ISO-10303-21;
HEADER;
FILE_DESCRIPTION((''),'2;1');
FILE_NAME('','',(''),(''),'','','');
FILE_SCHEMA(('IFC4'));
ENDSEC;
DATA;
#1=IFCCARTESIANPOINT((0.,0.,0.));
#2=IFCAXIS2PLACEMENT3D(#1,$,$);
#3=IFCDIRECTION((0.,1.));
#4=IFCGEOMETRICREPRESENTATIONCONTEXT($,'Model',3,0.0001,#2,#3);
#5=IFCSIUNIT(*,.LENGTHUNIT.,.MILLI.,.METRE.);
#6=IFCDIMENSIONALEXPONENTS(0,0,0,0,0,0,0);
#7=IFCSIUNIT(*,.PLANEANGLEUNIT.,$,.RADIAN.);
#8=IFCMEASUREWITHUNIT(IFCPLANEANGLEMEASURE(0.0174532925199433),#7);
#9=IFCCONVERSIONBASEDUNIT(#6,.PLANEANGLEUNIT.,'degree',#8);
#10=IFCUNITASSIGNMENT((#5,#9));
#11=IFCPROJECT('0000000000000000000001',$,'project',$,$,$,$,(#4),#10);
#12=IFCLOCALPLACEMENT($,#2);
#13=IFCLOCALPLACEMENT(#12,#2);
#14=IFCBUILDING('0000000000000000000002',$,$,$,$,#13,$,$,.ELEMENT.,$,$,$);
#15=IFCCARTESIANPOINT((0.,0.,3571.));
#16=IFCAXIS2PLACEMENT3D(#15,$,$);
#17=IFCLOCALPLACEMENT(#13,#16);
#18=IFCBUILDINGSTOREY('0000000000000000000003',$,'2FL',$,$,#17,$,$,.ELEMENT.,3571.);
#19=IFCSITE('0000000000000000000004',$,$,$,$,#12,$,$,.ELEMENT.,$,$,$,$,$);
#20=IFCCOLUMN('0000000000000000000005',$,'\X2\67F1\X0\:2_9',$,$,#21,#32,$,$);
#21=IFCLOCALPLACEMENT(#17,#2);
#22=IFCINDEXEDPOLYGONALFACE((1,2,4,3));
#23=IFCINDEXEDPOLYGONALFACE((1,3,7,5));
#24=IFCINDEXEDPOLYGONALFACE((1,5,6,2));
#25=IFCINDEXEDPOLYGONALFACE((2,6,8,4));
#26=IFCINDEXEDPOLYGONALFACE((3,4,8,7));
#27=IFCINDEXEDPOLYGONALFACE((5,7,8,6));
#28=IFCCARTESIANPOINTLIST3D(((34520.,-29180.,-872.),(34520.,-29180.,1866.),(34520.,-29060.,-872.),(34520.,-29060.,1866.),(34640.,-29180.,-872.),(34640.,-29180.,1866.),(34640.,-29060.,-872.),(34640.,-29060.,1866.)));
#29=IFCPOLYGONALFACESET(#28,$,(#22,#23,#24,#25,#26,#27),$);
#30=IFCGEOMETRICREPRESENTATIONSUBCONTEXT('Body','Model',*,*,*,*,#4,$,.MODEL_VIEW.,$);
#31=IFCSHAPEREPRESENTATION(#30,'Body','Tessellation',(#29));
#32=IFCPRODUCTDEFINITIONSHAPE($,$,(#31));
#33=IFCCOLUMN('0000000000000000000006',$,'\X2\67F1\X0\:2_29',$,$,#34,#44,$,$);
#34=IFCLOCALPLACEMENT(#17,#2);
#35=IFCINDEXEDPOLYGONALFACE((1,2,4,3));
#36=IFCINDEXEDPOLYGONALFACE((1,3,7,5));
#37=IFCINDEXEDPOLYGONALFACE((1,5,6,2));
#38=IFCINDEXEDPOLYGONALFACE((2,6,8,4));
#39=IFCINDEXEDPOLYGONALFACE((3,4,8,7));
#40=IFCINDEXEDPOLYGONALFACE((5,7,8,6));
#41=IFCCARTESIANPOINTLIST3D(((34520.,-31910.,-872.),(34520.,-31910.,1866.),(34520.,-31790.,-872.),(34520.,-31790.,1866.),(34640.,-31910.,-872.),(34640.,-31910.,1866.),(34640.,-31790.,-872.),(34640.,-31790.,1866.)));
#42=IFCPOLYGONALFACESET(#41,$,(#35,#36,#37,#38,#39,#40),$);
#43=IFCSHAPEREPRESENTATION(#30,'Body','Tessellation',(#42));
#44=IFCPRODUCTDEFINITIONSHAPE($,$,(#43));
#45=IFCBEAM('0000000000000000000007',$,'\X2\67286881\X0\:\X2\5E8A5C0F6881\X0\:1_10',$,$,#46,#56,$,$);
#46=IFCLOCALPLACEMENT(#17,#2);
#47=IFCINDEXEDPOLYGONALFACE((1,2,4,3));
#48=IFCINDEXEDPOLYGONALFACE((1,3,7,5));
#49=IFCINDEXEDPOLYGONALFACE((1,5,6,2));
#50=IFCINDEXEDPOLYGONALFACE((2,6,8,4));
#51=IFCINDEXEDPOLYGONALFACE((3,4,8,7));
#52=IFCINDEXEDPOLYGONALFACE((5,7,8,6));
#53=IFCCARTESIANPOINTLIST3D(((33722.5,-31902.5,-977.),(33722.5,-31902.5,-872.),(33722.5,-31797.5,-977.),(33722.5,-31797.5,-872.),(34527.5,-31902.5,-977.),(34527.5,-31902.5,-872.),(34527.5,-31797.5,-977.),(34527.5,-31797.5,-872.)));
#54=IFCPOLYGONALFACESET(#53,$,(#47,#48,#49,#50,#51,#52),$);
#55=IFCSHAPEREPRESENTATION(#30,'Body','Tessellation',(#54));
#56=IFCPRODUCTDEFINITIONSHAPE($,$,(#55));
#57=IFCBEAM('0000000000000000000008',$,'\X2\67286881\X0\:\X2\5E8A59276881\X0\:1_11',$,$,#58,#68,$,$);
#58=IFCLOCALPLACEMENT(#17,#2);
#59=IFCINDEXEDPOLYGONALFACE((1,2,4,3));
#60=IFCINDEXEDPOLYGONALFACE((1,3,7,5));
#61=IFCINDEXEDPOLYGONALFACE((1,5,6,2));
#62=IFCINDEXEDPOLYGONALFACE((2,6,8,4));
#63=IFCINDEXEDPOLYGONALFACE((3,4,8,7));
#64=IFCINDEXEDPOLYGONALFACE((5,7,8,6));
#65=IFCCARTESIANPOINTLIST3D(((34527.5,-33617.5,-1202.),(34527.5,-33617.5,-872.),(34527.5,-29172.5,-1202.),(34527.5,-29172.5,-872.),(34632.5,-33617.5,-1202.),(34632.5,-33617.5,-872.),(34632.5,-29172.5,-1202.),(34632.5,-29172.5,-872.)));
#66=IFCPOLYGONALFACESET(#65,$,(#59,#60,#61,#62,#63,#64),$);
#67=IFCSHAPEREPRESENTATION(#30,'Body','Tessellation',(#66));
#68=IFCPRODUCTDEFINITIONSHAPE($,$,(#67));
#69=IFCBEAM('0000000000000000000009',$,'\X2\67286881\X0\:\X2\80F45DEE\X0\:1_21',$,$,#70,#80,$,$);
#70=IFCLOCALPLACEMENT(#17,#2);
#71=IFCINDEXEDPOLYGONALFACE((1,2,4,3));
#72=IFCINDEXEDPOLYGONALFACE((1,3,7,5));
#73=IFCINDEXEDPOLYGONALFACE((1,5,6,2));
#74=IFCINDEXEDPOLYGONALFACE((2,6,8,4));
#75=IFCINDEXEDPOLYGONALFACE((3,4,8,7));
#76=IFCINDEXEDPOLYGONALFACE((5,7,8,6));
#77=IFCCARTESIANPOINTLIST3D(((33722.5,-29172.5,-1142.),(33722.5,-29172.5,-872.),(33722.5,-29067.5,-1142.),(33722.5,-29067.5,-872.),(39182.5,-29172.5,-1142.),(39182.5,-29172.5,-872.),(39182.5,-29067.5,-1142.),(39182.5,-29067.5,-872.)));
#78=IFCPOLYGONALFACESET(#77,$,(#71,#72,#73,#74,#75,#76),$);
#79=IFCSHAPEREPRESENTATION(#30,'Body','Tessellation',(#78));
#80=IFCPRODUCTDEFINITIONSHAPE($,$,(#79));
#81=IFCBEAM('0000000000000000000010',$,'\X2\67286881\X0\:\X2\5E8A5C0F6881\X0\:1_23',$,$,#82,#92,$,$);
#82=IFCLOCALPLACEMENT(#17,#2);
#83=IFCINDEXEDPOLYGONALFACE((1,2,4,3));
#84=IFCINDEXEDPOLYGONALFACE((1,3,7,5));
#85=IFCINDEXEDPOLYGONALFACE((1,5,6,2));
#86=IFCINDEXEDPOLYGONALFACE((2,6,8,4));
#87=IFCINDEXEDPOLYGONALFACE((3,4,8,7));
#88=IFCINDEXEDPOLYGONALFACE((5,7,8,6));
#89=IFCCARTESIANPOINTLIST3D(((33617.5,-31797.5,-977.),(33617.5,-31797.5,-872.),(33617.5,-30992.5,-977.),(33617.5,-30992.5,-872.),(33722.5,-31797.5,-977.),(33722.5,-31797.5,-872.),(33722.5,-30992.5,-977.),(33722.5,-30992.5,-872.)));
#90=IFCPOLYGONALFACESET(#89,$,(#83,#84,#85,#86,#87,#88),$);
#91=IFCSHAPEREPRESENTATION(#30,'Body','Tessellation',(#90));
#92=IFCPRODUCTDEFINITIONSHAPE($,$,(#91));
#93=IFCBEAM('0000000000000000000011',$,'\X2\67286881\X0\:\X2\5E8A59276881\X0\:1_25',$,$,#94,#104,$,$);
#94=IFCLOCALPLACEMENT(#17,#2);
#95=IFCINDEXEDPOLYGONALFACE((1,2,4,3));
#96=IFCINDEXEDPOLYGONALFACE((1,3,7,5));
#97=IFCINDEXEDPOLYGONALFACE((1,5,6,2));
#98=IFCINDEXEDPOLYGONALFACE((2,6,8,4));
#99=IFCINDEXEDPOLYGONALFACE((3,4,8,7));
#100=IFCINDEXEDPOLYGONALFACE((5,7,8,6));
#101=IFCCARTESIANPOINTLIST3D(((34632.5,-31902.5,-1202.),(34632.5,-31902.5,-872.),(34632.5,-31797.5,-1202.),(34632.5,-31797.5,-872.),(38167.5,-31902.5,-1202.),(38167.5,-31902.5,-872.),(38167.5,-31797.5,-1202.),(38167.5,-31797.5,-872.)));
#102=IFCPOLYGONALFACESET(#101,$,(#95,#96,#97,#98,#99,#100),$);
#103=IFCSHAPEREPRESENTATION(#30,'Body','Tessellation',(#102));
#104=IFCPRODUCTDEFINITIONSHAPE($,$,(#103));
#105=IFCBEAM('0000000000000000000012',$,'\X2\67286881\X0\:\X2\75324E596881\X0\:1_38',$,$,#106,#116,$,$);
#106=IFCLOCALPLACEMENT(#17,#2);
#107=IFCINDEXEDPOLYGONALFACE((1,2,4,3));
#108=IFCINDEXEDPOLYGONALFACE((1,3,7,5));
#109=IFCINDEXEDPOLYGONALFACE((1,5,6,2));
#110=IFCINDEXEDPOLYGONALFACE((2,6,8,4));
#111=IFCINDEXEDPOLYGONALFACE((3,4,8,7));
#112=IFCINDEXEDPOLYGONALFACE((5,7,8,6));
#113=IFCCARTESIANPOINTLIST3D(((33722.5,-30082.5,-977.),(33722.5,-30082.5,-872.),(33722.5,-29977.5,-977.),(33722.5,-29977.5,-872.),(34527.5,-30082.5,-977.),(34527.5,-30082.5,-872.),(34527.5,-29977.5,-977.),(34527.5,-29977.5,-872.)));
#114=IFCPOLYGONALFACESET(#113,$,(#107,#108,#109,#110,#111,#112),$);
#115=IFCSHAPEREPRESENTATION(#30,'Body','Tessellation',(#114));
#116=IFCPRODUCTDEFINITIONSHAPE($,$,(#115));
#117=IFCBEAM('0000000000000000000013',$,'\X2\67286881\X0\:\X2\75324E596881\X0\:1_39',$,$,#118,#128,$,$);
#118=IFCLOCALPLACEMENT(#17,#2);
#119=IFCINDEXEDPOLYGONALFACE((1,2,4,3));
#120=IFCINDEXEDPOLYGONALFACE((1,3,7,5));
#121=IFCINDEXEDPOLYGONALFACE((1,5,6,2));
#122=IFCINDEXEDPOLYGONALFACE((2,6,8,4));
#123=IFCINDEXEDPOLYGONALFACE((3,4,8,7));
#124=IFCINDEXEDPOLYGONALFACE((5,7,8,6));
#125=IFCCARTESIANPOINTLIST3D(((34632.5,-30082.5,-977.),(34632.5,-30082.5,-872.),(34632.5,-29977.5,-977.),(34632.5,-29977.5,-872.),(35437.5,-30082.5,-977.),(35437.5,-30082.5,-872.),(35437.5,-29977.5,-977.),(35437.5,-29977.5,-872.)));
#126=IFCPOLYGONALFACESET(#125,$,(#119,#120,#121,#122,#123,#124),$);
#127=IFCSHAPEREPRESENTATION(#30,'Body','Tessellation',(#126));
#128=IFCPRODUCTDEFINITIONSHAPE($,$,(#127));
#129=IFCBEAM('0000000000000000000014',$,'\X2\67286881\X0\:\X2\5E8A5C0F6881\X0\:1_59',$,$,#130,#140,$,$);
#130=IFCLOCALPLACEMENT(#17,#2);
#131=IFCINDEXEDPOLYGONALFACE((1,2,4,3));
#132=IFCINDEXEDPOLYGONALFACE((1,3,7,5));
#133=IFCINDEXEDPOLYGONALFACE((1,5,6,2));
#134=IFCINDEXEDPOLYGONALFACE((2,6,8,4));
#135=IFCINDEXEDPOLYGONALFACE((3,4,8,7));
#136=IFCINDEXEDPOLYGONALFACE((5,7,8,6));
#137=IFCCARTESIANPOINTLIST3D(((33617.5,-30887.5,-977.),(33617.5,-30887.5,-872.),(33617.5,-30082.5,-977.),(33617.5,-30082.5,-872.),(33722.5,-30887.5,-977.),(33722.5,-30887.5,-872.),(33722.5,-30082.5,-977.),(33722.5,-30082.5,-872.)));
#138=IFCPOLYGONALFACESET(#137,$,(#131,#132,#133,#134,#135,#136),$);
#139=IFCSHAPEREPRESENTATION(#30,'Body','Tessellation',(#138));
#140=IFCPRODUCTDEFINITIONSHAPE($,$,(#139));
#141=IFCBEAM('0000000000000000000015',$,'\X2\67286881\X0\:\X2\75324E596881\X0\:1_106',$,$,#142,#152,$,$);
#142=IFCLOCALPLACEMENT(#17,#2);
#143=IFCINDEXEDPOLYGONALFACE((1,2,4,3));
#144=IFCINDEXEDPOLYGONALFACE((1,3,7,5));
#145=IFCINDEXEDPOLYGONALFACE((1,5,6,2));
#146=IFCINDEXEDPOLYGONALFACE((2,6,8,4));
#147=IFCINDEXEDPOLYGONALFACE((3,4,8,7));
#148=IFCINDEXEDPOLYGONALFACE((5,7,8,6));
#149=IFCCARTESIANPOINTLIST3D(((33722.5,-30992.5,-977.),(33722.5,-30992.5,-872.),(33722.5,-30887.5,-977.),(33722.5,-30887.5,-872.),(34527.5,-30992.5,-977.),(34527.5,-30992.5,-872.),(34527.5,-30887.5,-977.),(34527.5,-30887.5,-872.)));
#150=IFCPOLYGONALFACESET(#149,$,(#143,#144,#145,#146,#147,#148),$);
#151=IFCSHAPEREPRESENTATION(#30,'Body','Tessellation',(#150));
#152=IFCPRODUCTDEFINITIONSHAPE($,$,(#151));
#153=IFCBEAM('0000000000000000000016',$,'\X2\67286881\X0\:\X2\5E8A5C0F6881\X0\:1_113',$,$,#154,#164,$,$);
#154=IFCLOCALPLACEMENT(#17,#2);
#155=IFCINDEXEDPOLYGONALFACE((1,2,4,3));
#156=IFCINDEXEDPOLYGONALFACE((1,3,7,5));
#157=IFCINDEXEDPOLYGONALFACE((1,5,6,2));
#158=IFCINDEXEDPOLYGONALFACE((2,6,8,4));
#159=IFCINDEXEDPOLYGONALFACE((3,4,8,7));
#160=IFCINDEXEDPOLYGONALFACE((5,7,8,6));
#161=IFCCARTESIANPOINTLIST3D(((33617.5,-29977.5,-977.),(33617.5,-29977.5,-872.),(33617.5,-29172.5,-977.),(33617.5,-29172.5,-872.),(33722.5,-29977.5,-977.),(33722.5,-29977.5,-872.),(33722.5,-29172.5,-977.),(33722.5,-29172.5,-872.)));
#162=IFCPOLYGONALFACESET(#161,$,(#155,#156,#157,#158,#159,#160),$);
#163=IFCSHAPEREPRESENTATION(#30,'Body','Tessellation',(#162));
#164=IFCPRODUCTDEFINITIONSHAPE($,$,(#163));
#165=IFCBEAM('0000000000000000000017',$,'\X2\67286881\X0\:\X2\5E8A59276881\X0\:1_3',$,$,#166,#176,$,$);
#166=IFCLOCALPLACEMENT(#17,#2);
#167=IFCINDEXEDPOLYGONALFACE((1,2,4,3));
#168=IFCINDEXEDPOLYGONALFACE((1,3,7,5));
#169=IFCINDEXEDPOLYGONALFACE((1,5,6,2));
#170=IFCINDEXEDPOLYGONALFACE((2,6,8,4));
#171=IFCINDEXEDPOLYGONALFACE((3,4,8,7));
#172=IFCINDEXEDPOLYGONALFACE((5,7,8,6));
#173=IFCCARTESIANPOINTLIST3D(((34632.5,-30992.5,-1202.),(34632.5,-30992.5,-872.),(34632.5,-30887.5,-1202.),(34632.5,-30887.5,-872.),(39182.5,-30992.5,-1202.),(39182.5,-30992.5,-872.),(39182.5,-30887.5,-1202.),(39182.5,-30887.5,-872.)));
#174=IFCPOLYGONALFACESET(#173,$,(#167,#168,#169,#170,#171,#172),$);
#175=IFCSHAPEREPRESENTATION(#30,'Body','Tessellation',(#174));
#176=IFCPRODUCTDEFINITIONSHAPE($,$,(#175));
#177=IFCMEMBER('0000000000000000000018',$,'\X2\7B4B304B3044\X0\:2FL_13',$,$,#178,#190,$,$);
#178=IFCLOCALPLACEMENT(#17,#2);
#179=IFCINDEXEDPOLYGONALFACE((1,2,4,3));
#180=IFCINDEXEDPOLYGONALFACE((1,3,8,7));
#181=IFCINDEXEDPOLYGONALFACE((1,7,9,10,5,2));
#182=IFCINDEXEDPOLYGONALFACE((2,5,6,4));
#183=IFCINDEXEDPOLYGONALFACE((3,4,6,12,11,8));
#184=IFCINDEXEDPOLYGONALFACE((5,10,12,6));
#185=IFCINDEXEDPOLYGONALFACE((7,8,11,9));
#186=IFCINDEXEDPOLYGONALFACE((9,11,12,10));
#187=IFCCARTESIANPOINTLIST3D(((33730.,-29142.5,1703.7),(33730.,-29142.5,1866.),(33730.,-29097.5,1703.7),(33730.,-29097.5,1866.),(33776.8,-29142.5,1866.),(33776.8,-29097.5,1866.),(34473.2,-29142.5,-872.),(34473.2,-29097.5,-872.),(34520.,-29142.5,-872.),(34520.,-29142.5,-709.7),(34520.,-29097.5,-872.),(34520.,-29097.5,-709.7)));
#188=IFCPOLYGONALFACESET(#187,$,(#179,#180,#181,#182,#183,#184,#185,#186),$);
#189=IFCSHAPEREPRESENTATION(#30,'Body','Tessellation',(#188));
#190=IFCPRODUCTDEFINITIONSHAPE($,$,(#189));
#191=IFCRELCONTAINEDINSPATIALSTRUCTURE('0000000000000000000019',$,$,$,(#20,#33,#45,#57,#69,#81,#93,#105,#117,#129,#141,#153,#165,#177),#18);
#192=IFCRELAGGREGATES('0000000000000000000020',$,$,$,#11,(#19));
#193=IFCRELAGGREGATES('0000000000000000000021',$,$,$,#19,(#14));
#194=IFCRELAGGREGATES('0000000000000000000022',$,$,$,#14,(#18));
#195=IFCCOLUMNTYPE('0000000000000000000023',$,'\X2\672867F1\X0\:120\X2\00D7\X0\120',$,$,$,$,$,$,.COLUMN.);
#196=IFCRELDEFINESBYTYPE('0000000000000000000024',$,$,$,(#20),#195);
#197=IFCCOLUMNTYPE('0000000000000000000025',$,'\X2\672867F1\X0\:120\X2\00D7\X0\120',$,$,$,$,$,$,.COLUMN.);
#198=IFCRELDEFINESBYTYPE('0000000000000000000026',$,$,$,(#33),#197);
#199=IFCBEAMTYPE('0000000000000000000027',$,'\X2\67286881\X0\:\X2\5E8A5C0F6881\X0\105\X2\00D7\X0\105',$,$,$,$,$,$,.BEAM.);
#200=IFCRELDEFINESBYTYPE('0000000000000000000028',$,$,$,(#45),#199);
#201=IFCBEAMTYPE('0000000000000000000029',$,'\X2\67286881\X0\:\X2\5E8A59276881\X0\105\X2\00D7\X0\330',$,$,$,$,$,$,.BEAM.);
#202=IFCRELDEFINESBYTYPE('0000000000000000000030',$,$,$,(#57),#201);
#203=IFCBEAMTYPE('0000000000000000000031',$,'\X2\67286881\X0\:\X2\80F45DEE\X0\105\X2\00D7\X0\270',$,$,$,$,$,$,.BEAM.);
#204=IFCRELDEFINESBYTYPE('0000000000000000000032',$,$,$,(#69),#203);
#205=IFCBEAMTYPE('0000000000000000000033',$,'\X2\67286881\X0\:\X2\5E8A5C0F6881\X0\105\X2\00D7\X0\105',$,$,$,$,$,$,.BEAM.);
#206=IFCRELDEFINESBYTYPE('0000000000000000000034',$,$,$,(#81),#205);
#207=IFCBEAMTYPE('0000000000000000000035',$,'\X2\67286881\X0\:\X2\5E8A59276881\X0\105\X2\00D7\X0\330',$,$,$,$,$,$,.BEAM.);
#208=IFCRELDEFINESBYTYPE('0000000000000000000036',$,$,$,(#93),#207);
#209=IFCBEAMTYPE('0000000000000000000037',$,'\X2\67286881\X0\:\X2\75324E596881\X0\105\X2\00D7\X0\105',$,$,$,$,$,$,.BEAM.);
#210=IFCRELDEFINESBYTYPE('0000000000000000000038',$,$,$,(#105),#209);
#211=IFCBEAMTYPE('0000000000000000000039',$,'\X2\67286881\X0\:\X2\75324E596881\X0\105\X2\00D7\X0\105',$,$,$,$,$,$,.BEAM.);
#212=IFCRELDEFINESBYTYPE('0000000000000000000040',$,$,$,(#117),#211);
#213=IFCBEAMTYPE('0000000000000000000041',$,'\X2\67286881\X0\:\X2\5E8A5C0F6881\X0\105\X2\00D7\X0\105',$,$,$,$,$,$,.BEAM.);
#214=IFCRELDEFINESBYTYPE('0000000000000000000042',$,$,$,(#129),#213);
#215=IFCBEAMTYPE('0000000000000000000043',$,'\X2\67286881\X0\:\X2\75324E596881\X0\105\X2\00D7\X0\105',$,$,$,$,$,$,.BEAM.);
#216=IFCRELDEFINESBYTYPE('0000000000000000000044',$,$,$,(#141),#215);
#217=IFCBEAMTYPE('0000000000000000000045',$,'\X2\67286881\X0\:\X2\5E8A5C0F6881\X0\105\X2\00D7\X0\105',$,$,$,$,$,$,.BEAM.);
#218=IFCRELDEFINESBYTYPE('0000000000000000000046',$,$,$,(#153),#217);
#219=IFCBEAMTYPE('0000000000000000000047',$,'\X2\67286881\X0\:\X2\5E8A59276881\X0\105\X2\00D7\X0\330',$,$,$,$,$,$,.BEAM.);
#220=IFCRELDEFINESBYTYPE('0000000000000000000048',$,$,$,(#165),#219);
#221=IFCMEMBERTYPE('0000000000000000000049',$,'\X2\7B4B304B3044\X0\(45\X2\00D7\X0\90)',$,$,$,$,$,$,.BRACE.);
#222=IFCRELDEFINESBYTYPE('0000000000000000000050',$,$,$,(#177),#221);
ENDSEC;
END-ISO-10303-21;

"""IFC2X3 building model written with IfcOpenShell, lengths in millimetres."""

from ifc_helpers import new_model, entity, si_unit, converted_unit, direction, frame, origin, origin_with_axes, origin_2d, place, context, subcontext, project, spatial, polyline, rectangle, outline, extrude, type_object, element, save


model = new_model("IFC2X3")

# Units and contexts
model_context = context("Model", 3, precision=0.0001, world=origin(), true_north=direction((0.0, 1.0)))
body_context = subcontext(model_context, "Body", "Model", "MODEL_VIEW")
ifc_project = project(units=[si_unit("LENGTHUNIT", "METRE", prefix="MILLI"), converted_unit("PLANEANGLEUNIT", "degree", entity("IfcPlaneAngleMeasure", 0.0174532925199433), si_unit("PLANEANGLEUNIT", "RADIAN"), dimensions=[0, 0, 0, 0, 0, 0, 0])], contexts=[model_context])

# Site, building, storey
site_placement = place(None, origin())
site = spatial("IfcSite", under=ifc_project, at=site_placement, CompositionType="ELEMENT")
building_placement = place(site_placement, origin())
building = spatial("IfcBuilding", under=site, at=building_placement, CompositionType="ELEMENT")
storey_placement = place(building_placement, frame((0.0, 0.0, 3571.0)))
storey = spatial("IfcBuildingStorey", under=building, at=storey_placement, Name="2FL", CompositionType="ELEMENT", Elevation=3571.0)

# Columns
column_type_1 = type_object("IfcColumnType", Name="木柱:120×120", PredefinedType="COLUMN")
column_1_placement = place(storey_placement, frame((34580.0, -29120.0, -872.0)))
element("IfcColumn", 1, at=column_1_placement, inside=storey, type_object=column_type_1, Name="柱:2_9", context=body_context, shape_type="SweptSolid", body=[
    extrude(rectangle(XDim=120.0, YDim=120.0, at=origin_2d()), origin_with_axes(), (0.0, 0.0, 1.0), 2738.0),
])
column_type_2 = type_object("IfcColumnType", Name="木柱:120×120", PredefinedType="COLUMN")
column_2_placement = place(storey_placement, frame((34580.0, -31850.0, -872.0)))
element("IfcColumn", 2, at=column_2_placement, inside=storey, type_object=column_type_2, Name="柱:2_29", context=body_context, shape_type="SweptSolid", body=[
    extrude(rectangle(XDim=120.0, YDim=120.0, at=origin_2d()), origin_with_axes(), (0.0, 0.0, 1.0), 2738.0),
])

# Beams
beam_type_1 = type_object("IfcBeamType", Name="木梁:床小梁105×105", PredefinedType="BEAM")
beam_1_placement = place(storey_placement, frame((33722.5, -31850.0, -924.5), z_axis=(1.0, 0.0, 0.0), x_axis=(0.0, 1.0, 0.0)))
element("IfcBeam", 3, at=beam_1_placement, inside=storey, type_object=beam_type_1, Name="木梁:床小梁:1_10", context=body_context, shape_type="SweptSolid", body=[
    extrude(rectangle(XDim=105.0, YDim=105.0, at=origin_2d()), origin_with_axes(), (0.0, 0.0, 1.0), 805.0),
])
beam_type_2 = type_object("IfcBeamType", Name="木梁:床大梁105×330", PredefinedType="BEAM")
beam_2_placement = place(storey_placement, frame((34580.0, -29172.5, -1037.0), z_axis=(0.0, -1.0, 0.0), x_axis=(1.0, 0.0, 0.0)))
element("IfcBeam", 4, at=beam_2_placement, inside=storey, type_object=beam_type_2, Name="木梁:床大梁:1_11", context=body_context, shape_type="SweptSolid", body=[
    extrude(rectangle(XDim=105.0, YDim=330.0, at=origin_2d()), origin_with_axes(), (0.0, 0.0, 1.0), 4445.0),
])
beam_type_3 = type_object("IfcBeamType", Name="木梁:胴差105×270", PredefinedType="BEAM")
beam_3_placement = place(storey_placement, frame((33722.5, -29120.0, -1007.0), z_axis=(1.0, 0.0, 0.0), x_axis=(0.0, 1.0, 0.0)))
element("IfcBeam", 5, at=beam_3_placement, inside=storey, type_object=beam_type_3, Name="木梁:胴差:1_21", context=body_context, shape_type="SweptSolid", body=[
    extrude(rectangle(XDim=105.0, YDim=270.0, at=origin_2d()), origin_with_axes(), (0.0, 0.0, 1.0), 5460.0),
])
beam_type_4 = type_object("IfcBeamType", Name="木梁:床小梁105×105", PredefinedType="BEAM")
beam_4_placement = place(storey_placement, frame((33670.0, -30992.5, -924.5), z_axis=(0.0, -1.0, 0.0), x_axis=(1.0, 0.0, 0.0)))
element("IfcBeam", 6, at=beam_4_placement, inside=storey, type_object=beam_type_4, Name="木梁:床小梁:1_23", context=body_context, shape_type="SweptSolid", body=[
    extrude(rectangle(XDim=105.0, YDim=105.0, at=origin_2d()), origin_with_axes(), (0.0, 0.0, 1.0), 805.0),
])
beam_type_5 = type_object("IfcBeamType", Name="木梁:床大梁105×330", PredefinedType="BEAM")
beam_5_placement = place(storey_placement, frame((34632.5, -31850.0, -1037.0), z_axis=(1.0, 0.0, 0.0), x_axis=(0.0, 1.0, 0.0)))
element("IfcBeam", 7, at=beam_5_placement, inside=storey, type_object=beam_type_5, Name="木梁:床大梁:1_25", context=body_context, shape_type="SweptSolid", body=[
    extrude(rectangle(XDim=105.0, YDim=330.0, at=origin_2d()), origin_with_axes(), (0.0, 0.0, 1.0), 3535.0),
])
beam_type_6 = type_object("IfcBeamType", Name="木梁:甲乙梁105×105", PredefinedType="BEAM")
beam_6_placement = place(storey_placement, frame((33722.5, -30030.0, -924.5), z_axis=(1.0, 0.0, 0.0), x_axis=(0.0, 1.0, 0.0)))
element("IfcBeam", 8, at=beam_6_placement, inside=storey, type_object=beam_type_6, Name="木梁:甲乙梁:1_38", context=body_context, shape_type="SweptSolid", body=[
    extrude(rectangle(XDim=105.0, YDim=105.0, at=origin_2d()), origin_with_axes(), (0.0, 0.0, 1.0), 805.0),
])
beam_type_7 = type_object("IfcBeamType", Name="木梁:甲乙梁105×105", PredefinedType="BEAM")
beam_7_placement = place(storey_placement, frame((34632.5, -30030.0, -924.5), z_axis=(1.0, 0.0, 0.0), x_axis=(0.0, 1.0, 0.0)))
element("IfcBeam", 9, at=beam_7_placement, inside=storey, type_object=beam_type_7, Name="木梁:甲乙梁:1_39", context=body_context, shape_type="SweptSolid", body=[
    extrude(rectangle(XDim=105.0, YDim=105.0, at=origin_2d()), origin_with_axes(), (0.0, 0.0, 1.0), 805.0),
])
beam_type_8 = type_object("IfcBeamType", Name="木梁:床小梁105×105", PredefinedType="BEAM")
beam_8_placement = place(storey_placement, frame((33670.0, -30082.5, -924.5), z_axis=(0.0, -1.0, 0.0), x_axis=(1.0, 0.0, 0.0)))
element("IfcBeam", 10, at=beam_8_placement, inside=storey, type_object=beam_type_8, Name="木梁:床小梁:1_59", context=body_context, shape_type="SweptSolid", body=[
    extrude(rectangle(XDim=105.0, YDim=105.0, at=origin_2d()), origin_with_axes(), (0.0, 0.0, 1.0), 805.0),
])
beam_type_9 = type_object("IfcBeamType", Name="木梁:甲乙梁105×105", PredefinedType="BEAM")
beam_9_placement = place(storey_placement, frame((33722.5, -30940.0, -924.5), z_axis=(1.0, 0.0, 0.0), x_axis=(0.0, 1.0, 0.0)))
element("IfcBeam", 11, at=beam_9_placement, inside=storey, type_object=beam_type_9, Name="木梁:甲乙梁:1_106", context=body_context, shape_type="SweptSolid", body=[
    extrude(rectangle(XDim=105.0, YDim=105.0, at=origin_2d()), origin_with_axes(), (0.0, 0.0, 1.0), 805.0),
])
beam_type_10 = type_object("IfcBeamType", Name="木梁:床小梁105×105", PredefinedType="BEAM")
beam_10_placement = place(storey_placement, frame((33670.0, -29172.5, -924.5), z_axis=(0.0, -1.0, 0.0), x_axis=(1.0, 0.0, 0.0)))
element("IfcBeam", 12, at=beam_10_placement, inside=storey, type_object=beam_type_10, Name="木梁:床小梁:1_113", context=body_context, shape_type="SweptSolid", body=[
    extrude(rectangle(XDim=105.0, YDim=105.0, at=origin_2d()), origin_with_axes(), (0.0, 0.0, 1.0), 805.0),
])
beam_type_11 = type_object("IfcBeamType", Name="木梁:床大梁105×330", PredefinedType="BEAM")
beam_11_placement = place(storey_placement, frame((34632.5, -30940.0, -1037.0), z_axis=(1.0, 0.0, 0.0), x_axis=(0.0, 1.0, 0.0)))
element("IfcBeam", 13, at=beam_11_placement, inside=storey, type_object=beam_type_11, Name="木梁:床大梁:1_3", context=body_context, shape_type="SweptSolid", body=[
    extrude(rectangle(XDim=105.0, YDim=330.0, at=origin_2d()), origin_with_axes(), (0.0, 0.0, 1.0), 4550.0),
])

# Member
member_type = type_object("IfcMemberType", Name="筋かい(45×90)", PredefinedType="BRACE")
member_placement = place(storey_placement, frame((34520.0, -29120.0, -872.0), z_axis=(-0.277223, 0.0, 0.960806), x_axis=(0.960806, 0.0, 0.277223)))
element("IfcMember", 14, at=member_placement, inside=storey, type_object=member_type, Name="筋かい:2FL_13", context=body_context, shape_type="SweptSolid", body=[
    extrude(outline(polyline([(0.0, 0.0), (13.0, -45.0), (2693.7, -45.0), (2849.7, 0.0), (2836.7, 45.0), (156.0, 45.0), (0.0, 0.0)])), frame((0.0, -22.5, 0.0), z_axis=(0.0, 1.0, 0.0), x_axis=(0.0, 0.0, 1.0)), (0.0, 0.0, 1.0), 45.0),
])

save(model, "model.ifc")
